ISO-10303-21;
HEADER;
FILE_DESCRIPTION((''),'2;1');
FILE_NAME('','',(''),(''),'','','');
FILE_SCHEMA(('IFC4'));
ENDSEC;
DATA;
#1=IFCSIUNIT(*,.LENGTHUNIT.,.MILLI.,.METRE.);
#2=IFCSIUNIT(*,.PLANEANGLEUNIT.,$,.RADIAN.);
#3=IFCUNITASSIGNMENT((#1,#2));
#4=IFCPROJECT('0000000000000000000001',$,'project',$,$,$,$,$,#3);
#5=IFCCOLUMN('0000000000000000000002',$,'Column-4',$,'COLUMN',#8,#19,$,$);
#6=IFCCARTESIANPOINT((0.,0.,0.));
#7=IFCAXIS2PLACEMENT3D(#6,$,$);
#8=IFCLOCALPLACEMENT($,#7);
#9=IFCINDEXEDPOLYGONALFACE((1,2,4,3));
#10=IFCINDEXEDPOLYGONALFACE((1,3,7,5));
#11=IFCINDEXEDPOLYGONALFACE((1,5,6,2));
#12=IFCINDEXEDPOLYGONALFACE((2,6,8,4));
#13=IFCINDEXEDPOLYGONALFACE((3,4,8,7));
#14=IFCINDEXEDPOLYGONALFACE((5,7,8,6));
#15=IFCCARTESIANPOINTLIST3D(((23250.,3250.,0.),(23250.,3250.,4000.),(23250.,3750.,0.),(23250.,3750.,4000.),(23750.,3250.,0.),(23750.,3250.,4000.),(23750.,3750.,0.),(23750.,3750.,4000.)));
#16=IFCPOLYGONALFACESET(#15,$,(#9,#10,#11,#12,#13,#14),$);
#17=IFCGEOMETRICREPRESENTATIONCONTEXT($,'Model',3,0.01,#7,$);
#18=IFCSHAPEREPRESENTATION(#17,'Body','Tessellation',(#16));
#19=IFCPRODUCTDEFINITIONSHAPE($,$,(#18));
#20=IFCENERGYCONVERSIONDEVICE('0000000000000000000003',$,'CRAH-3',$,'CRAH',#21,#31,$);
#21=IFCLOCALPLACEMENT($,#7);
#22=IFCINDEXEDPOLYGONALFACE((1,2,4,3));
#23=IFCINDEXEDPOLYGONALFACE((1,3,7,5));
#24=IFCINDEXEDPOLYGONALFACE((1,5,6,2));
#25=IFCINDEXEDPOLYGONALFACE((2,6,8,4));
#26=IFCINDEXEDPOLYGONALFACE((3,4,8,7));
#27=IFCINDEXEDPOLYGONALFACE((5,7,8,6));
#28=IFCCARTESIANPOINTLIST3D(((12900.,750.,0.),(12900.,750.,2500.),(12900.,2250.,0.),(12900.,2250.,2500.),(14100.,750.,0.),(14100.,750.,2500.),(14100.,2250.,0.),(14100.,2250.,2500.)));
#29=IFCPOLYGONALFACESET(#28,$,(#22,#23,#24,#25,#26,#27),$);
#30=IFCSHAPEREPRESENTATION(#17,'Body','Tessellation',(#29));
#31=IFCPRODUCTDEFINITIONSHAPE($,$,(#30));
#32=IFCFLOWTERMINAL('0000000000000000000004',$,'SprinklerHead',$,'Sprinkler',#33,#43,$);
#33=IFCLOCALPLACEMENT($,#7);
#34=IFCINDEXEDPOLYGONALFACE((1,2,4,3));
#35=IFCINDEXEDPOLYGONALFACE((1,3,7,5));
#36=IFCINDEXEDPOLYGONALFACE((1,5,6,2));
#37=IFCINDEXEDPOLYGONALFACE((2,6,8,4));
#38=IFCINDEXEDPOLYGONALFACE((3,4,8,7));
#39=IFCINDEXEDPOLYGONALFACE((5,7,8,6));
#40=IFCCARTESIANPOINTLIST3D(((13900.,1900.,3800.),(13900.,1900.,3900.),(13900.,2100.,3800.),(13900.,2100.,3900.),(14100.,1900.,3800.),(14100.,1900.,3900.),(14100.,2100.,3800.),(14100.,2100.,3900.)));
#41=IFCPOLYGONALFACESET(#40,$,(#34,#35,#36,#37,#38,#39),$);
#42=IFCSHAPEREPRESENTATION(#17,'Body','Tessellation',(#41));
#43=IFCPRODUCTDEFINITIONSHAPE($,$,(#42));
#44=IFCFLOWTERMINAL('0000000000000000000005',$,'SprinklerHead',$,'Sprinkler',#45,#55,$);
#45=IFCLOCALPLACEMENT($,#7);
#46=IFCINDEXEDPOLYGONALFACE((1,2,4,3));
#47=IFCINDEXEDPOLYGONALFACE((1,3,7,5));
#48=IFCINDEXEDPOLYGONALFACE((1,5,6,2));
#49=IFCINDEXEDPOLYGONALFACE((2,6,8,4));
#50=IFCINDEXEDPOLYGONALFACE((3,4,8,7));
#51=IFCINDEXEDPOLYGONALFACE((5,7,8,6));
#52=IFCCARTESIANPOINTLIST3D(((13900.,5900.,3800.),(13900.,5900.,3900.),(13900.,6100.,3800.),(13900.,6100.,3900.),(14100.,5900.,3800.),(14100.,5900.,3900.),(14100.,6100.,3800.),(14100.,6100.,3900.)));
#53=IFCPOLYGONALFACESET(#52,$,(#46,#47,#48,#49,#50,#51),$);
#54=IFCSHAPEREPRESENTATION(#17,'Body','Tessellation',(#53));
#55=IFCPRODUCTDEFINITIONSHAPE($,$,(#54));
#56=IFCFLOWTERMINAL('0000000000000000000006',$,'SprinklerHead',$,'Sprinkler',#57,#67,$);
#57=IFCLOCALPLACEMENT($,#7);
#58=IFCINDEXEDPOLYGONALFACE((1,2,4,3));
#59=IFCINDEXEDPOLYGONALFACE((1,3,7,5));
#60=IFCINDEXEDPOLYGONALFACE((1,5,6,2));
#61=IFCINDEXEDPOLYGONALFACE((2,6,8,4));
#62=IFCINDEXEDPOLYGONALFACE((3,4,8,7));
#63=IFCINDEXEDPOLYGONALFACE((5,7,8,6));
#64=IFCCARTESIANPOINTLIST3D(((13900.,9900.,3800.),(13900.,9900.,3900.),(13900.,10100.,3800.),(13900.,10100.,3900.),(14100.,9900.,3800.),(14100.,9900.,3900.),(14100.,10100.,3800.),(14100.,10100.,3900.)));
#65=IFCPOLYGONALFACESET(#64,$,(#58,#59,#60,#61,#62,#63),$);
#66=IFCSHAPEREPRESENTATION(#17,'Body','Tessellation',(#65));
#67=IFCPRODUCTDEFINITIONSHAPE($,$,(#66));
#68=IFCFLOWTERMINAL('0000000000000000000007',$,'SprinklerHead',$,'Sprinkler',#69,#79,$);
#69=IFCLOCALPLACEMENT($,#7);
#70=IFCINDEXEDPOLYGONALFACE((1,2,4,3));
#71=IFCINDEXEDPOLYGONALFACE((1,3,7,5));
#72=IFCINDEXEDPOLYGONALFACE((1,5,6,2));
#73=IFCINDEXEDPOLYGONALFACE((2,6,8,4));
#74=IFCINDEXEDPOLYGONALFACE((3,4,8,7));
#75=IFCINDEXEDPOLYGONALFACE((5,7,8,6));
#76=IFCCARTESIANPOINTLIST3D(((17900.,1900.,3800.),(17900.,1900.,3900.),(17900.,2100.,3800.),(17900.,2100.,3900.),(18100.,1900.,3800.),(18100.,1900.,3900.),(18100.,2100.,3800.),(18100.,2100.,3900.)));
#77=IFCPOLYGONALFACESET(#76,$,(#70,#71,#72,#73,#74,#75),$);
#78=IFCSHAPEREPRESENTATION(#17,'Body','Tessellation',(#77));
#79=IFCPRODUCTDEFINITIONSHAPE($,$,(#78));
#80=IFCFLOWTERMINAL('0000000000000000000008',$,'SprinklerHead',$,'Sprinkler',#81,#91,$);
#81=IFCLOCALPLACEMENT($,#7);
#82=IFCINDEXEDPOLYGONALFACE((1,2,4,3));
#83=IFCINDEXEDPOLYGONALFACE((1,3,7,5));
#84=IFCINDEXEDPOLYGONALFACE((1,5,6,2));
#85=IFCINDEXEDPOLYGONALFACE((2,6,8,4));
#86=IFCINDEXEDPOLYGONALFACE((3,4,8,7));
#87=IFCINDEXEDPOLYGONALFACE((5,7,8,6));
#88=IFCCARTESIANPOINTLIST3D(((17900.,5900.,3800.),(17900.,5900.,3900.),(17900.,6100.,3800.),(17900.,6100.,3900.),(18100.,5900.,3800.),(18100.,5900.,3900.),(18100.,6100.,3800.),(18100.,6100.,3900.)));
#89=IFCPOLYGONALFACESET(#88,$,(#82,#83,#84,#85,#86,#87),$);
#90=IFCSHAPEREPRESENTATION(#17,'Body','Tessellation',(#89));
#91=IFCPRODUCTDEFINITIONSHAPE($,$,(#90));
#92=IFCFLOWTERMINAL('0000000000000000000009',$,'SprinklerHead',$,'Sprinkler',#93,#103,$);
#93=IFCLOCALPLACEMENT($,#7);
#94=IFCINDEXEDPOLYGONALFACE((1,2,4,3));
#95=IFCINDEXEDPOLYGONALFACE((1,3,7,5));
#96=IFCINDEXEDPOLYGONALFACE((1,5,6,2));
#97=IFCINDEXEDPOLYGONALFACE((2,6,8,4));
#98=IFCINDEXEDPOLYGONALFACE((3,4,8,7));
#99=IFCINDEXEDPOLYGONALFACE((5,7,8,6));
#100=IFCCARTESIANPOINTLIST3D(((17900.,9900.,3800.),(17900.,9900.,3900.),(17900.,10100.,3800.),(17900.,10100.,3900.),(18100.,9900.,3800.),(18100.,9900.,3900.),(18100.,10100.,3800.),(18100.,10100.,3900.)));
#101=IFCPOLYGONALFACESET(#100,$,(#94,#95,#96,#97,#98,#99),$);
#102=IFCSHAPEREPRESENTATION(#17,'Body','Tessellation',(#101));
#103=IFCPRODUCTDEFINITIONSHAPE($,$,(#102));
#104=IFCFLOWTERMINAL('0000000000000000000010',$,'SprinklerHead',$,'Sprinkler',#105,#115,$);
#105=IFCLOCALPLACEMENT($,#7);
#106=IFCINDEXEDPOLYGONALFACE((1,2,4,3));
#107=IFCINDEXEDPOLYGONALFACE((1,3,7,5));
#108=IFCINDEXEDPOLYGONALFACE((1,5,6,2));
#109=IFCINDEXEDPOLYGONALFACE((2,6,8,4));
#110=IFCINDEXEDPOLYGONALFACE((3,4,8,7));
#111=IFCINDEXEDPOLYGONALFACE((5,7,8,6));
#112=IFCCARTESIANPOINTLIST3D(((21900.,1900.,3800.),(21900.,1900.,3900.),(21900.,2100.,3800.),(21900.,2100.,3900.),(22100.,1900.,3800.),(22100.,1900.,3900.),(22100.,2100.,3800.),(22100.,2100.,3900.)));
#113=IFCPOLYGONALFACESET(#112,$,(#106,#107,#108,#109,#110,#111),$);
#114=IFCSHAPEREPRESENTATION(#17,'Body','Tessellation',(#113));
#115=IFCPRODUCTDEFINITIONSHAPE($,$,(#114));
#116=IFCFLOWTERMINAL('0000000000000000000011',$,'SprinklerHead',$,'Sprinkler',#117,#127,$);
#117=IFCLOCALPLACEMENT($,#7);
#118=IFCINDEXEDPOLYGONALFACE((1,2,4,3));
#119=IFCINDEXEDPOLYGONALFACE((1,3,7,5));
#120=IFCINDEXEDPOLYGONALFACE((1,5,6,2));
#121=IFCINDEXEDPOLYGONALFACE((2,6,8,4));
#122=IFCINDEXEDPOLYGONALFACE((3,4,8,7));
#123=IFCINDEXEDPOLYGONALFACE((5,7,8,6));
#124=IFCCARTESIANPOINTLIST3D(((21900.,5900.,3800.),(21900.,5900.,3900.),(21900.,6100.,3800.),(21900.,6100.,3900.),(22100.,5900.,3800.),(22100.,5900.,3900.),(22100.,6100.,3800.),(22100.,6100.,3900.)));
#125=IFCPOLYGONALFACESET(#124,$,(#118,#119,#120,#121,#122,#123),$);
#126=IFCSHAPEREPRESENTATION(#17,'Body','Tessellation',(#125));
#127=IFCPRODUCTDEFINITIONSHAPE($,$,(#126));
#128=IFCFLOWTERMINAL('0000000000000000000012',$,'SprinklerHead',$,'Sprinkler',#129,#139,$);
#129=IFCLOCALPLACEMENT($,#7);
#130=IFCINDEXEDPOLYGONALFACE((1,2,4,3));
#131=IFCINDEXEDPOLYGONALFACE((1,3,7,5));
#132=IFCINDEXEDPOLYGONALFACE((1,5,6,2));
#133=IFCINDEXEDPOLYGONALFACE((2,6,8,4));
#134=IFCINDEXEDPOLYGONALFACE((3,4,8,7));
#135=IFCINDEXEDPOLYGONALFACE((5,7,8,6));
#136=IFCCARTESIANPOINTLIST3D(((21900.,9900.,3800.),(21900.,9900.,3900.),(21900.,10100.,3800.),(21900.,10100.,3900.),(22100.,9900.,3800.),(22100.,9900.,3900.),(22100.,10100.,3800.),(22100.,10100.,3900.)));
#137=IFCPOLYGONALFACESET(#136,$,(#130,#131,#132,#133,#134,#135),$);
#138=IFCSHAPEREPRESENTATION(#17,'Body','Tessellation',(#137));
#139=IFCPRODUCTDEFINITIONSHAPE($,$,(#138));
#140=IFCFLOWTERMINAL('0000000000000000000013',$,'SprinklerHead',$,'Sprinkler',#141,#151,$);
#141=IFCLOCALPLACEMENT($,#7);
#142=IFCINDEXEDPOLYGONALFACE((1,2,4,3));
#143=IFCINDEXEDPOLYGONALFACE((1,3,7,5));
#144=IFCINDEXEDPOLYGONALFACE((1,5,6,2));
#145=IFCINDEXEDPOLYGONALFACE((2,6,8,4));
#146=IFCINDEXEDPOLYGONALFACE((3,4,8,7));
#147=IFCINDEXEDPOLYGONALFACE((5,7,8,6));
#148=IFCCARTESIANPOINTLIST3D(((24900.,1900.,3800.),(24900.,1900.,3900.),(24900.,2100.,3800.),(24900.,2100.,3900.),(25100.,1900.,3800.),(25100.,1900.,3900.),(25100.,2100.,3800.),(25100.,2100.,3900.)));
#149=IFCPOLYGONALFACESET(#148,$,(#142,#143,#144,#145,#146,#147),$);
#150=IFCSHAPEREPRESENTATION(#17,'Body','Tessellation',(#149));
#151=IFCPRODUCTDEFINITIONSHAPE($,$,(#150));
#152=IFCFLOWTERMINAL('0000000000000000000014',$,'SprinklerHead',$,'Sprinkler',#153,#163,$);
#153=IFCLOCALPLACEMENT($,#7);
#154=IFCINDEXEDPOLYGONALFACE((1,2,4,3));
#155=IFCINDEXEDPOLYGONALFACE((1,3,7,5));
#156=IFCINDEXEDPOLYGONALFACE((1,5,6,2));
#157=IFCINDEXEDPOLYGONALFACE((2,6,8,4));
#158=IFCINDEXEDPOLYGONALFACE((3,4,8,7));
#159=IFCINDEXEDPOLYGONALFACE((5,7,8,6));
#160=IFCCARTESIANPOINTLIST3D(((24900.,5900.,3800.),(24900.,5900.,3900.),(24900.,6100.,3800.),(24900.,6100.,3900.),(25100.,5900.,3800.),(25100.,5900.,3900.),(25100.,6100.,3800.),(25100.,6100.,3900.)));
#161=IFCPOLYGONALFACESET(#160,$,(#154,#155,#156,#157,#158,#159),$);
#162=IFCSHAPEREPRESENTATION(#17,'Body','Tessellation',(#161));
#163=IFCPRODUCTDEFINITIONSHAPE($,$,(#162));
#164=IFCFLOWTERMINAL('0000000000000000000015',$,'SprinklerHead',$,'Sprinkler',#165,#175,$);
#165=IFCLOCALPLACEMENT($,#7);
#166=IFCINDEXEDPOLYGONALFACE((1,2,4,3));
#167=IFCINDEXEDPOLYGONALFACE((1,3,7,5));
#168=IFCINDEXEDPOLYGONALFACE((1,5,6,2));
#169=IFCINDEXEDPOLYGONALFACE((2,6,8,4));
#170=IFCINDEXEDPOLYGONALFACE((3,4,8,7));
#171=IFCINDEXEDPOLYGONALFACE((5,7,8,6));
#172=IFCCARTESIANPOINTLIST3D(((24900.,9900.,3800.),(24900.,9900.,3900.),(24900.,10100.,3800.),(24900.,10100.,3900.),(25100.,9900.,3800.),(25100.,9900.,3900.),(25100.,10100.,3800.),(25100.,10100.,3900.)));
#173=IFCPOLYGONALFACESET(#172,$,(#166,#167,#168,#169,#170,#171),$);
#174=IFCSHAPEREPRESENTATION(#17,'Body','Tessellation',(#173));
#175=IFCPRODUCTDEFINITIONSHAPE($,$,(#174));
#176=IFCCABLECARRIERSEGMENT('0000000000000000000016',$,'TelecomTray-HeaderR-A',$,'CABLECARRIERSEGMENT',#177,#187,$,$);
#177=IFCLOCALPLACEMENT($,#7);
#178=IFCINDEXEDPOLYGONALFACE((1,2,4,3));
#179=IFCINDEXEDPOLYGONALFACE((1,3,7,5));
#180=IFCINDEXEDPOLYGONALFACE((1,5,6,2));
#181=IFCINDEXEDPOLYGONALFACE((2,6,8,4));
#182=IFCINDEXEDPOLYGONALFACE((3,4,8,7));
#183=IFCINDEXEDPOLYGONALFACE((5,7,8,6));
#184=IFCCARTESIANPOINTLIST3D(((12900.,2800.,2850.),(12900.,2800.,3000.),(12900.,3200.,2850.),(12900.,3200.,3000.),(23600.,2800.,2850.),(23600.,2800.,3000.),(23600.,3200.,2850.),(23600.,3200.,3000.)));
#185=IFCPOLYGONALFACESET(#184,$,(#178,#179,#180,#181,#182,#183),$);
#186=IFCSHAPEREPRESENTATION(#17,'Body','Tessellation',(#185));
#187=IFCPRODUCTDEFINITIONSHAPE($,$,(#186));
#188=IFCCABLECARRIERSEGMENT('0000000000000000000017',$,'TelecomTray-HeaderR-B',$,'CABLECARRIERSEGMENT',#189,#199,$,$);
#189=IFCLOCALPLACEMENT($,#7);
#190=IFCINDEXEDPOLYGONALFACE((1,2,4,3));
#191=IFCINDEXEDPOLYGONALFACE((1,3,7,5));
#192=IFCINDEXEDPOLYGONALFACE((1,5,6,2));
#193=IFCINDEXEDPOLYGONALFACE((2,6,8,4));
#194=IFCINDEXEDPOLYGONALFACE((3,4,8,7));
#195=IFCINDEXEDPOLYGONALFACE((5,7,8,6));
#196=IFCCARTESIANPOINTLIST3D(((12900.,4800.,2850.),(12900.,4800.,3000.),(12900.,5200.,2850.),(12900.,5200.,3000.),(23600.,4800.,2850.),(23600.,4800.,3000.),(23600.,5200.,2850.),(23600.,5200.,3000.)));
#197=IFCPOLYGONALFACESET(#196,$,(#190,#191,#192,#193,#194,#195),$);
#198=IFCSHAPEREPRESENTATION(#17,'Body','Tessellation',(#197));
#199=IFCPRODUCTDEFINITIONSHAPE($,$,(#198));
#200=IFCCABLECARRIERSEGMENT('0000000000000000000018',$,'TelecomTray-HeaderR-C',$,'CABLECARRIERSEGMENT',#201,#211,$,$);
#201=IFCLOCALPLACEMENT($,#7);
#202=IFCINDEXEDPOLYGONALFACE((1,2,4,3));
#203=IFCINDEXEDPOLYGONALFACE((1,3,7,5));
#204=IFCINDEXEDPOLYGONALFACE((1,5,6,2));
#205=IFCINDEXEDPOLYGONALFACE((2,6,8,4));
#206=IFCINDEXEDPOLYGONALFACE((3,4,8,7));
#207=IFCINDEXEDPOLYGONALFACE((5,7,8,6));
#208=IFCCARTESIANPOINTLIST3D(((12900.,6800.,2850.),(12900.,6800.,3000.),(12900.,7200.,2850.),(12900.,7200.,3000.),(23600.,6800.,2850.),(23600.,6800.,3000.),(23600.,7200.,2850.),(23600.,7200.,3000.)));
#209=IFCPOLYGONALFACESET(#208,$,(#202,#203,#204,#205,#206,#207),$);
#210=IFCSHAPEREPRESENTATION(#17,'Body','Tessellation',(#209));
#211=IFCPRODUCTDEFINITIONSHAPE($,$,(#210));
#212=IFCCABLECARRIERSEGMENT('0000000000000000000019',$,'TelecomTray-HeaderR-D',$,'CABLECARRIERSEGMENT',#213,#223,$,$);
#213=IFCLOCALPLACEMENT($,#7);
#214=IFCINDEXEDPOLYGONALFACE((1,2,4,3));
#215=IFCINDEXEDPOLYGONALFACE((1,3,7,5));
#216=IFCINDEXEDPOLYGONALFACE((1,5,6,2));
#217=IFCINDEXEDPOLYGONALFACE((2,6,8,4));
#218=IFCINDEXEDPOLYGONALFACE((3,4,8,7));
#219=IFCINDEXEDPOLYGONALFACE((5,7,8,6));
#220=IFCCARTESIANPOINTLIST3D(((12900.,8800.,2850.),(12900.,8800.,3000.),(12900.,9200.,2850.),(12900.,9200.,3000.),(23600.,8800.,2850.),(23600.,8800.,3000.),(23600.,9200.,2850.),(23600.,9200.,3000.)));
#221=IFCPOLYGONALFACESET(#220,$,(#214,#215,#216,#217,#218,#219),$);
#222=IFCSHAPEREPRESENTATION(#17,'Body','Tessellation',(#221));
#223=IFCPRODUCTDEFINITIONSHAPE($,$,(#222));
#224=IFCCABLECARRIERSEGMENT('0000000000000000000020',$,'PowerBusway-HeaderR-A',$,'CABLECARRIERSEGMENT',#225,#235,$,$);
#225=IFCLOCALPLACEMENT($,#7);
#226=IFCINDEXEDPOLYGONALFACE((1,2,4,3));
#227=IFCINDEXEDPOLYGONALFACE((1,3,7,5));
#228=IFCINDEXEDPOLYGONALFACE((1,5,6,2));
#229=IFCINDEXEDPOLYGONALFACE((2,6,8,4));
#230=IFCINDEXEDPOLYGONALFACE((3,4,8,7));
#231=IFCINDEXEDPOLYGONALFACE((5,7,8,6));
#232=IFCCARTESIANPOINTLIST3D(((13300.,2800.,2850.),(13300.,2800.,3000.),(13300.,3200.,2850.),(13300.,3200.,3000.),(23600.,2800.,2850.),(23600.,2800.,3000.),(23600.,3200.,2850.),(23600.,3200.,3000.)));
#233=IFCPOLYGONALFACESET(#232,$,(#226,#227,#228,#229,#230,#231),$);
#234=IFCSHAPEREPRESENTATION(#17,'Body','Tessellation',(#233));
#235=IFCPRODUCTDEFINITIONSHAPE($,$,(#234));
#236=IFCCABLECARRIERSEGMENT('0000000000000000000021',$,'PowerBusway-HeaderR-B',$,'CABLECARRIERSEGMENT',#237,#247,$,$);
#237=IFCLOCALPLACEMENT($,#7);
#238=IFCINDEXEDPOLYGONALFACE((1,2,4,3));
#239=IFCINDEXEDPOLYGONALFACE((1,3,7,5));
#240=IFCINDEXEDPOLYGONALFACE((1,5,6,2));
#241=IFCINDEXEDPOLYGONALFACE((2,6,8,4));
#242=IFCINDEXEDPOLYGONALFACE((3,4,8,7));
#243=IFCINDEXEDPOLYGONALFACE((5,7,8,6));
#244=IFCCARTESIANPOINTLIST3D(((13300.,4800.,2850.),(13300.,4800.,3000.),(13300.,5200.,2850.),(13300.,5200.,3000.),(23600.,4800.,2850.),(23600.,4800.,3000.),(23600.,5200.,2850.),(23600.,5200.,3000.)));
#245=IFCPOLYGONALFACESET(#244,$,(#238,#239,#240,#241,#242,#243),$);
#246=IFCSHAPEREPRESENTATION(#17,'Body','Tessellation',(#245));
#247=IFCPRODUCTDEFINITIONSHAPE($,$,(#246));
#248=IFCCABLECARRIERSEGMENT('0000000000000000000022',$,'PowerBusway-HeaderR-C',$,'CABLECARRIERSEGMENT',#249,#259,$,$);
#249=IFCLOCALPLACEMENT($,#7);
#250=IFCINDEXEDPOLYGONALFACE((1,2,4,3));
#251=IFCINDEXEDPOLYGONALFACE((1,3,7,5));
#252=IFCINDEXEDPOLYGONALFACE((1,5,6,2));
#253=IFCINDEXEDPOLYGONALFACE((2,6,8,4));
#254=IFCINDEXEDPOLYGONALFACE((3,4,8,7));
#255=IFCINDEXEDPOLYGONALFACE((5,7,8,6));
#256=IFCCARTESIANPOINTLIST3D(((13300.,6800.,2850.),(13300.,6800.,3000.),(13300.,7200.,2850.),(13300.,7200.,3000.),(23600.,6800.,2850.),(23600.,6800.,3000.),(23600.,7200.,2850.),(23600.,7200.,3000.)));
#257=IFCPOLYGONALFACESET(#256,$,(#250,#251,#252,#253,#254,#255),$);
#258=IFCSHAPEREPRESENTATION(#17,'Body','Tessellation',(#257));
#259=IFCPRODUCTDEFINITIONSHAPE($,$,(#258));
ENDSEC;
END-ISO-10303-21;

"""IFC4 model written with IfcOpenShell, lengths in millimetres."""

from ifc_helpers import new_model, si_unit, frame, origin, place, context, project, polyline, outline, extrude, element, save


model = new_model("IFC4")

# Units and contexts
model_context = context("Model", 3, precision=0.01, world=origin())
ifc_project = project(units=[si_unit("LENGTHUNIT", "METRE", prefix="MILLI"), si_unit("PLANEANGLEUNIT", "RADIAN")])

# Column
column_placement = place(None, frame((23500.0, 3500.0, 0.0)))
element("IfcColumn", 1, at=column_placement, Name="Column-4", ObjectType="COLUMN", context=model_context, shape_type="SweptSolid", body=[
    extrude(outline(polyline([(-250.0, -250.0), (250.0, -250.0), (250.0, 250.0), (-250.0, 250.0), (-250.0, -250.0)])), origin(), (0.0, 0.0, 1.0), 4000.0),
])

# Energy conversion device
energy_conversion_device_placement = place(None, frame((13500.0, 1500.0, 0.0)))
element("IfcEnergyConversionDevice", 2, at=energy_conversion_device_placement, Name="CRAH-3", ObjectType="CRAH", context=model_context, shape_type="SweptSolid", body=[
    extrude(outline(polyline([(-600.0, -750.0), (600.0, -750.0), (600.0, 750.0), (-600.0, 750.0), (-600.0, -750.0)])), origin(), (0.0, 0.0, 1.0), 2500.0),
])

# Flow terminals
for number, where, name in (
    (3, (14000.0, 2000.0, 3800.0), "SprinklerHead"),
    (4, (14000.0, 6000.0, 3800.0), "SprinklerHead"),
    (5, (14000.0, 10000.0, 3800.0), "SprinklerHead"),
    (6, (18000.0, 2000.0, 3800.0), "SprinklerHead"),
    (7, (18000.0, 6000.0, 3800.0), "SprinklerHead"),
    (8, (18000.0, 10000.0, 3800.0), "SprinklerHead"),
    (9, (22000.0, 2000.0, 3800.0), "SprinklerHead"),
    (10, (22000.0, 6000.0, 3800.0), "SprinklerHead"),
    (11, (22000.0, 10000.0, 3800.0), "SprinklerHead"),
    (12, (25000.0, 2000.0, 3800.0), "SprinklerHead"),
    (13, (25000.0, 6000.0, 3800.0), "SprinklerHead"),
    (14, (25000.0, 10000.0, 3800.0), "SprinklerHead"),
):
    element("IfcFlowTerminal", number, at=place(None, frame(where)), Name=name, ObjectType="Sprinkler", context=model_context, shape_type="SweptSolid", body=[
        extrude(outline(polyline([(-100.0, -100.0), (100.0, -100.0), (100.0, 100.0), (-100.0, 100.0), (-100.0, -100.0)])), origin(), (0.0, 0.0, 1.0), 100.0),
    ])

# Cable carrier segments
for number, where, name in (
    (15, (18250.0, 3000.0, 2850.0), "TelecomTray-HeaderR-A"),
    (16, (18250.0, 5000.0, 2850.0), "TelecomTray-HeaderR-B"),
    (17, (18250.0, 7000.0, 2850.0), "TelecomTray-HeaderR-C"),
    (18, (18250.0, 9000.0, 2850.0), "TelecomTray-HeaderR-D"),
):
    element("IfcCableCarrierSegment", number, at=place(None, frame(where)), Name=name, ObjectType="CABLECARRIERSEGMENT", context=model_context, shape_type="SweptSolid", body=[
        extrude(outline(polyline([(-5350.0, -200.0), (5350.0, -200.0), (5350.0, 200.0), (-5350.0, 200.0), (-5350.0, -200.0)])), origin(), (0.0, 0.0, 1.0), 150.0),
    ])
for number, where, name in (
    (19, (18450.0, 3000.0, 2850.0), "PowerBusway-HeaderR-A"),
    (20, (18450.0, 5000.0, 2850.0), "PowerBusway-HeaderR-B"),
    (21, (18450.0, 7000.0, 2850.0), "PowerBusway-HeaderR-C"),
):
    element("IfcCableCarrierSegment", number, at=place(None, frame(where)), Name=name, ObjectType="CABLECARRIERSEGMENT", context=model_context, shape_type="SweptSolid", body=[
        extrude(outline(polyline([(-5150.0, -200.0), (5150.0, -200.0), (5150.0, 200.0), (-5150.0, 200.0), (-5150.0, -200.0)])), origin(), (0.0, 0.0, 1.0), 150.0),
    ])

save(model, "model.ifc")
